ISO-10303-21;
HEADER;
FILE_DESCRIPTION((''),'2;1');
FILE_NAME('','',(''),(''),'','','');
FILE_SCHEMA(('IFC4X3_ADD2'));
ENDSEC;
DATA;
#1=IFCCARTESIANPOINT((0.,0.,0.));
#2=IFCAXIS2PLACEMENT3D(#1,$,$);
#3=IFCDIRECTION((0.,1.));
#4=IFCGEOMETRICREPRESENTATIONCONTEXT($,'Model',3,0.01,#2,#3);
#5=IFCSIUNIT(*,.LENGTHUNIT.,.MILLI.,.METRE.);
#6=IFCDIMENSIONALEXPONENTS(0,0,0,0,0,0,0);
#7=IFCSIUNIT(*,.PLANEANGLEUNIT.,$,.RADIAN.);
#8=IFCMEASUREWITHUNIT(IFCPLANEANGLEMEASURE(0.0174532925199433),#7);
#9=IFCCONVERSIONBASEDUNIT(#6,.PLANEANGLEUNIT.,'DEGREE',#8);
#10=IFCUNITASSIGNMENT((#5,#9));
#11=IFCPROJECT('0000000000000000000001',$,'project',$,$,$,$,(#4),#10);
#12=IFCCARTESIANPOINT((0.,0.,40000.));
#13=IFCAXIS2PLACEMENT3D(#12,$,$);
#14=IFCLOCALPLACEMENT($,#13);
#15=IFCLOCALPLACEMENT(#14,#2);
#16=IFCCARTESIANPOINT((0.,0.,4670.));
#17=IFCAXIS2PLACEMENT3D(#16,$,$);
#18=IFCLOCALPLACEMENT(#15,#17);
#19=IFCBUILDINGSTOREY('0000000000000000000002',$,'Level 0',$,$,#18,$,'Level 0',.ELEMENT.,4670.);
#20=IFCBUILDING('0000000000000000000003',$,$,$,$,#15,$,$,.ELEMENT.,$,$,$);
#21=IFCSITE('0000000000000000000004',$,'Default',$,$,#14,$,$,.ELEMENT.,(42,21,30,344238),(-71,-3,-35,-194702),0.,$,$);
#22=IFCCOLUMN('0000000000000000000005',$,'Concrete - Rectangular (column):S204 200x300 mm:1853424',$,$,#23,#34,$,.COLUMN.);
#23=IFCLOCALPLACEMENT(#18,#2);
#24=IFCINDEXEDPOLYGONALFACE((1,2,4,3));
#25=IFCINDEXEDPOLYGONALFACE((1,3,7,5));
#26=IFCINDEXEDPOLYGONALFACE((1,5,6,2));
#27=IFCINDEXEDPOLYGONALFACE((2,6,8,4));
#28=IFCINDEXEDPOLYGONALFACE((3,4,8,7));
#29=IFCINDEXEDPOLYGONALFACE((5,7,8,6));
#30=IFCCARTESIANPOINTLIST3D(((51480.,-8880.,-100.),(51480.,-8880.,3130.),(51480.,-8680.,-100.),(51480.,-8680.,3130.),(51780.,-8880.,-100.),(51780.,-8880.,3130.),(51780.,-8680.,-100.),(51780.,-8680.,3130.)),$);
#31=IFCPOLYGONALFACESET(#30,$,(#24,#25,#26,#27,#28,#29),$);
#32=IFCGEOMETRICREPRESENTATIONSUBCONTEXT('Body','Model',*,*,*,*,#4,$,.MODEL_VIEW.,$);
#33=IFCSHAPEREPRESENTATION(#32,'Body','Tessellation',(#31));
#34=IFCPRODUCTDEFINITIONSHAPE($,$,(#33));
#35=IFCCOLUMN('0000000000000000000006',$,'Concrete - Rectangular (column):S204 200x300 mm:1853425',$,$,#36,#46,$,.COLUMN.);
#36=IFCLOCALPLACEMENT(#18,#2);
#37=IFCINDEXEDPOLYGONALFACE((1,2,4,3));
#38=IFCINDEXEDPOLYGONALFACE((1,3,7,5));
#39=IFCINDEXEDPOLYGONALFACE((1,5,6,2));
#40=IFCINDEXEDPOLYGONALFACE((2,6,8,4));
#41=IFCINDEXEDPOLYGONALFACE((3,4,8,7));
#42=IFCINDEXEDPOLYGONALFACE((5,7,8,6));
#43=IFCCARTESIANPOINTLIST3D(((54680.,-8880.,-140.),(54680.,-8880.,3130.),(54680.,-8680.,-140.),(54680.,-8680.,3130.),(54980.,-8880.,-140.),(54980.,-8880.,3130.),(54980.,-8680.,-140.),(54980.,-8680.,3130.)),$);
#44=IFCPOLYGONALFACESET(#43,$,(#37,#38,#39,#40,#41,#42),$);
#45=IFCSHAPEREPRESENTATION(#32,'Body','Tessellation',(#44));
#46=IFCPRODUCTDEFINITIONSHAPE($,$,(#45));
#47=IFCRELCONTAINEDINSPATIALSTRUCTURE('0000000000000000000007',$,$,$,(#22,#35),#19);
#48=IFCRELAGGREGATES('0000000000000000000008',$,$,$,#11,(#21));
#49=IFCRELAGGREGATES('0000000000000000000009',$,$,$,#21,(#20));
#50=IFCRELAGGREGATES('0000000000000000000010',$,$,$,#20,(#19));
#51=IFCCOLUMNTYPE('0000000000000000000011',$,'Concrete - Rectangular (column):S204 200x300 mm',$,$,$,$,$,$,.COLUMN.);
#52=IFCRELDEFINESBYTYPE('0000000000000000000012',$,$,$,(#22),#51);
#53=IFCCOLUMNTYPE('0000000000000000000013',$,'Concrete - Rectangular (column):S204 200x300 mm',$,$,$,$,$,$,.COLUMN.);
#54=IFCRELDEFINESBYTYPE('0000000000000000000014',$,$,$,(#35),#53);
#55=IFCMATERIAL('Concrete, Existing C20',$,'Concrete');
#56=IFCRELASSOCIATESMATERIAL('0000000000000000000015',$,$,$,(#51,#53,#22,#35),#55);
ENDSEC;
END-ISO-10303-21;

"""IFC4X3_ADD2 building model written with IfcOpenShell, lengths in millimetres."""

from ifc_helpers import new_model, entity, si_unit, converted_unit, direction, frame, frame_2d, origin, place, context, subcontext, project, spatial, rectangle, extrude, source, transform, mapped, material, material_profile, profile_set, profile_usage, type_object, type_shapes, element, save


model = new_model("IFC4X3_ADD2")

# Units and contexts
model_context = context("Model", 3, precision=0.01, world=origin(), true_north=direction((0.0, 1.0)))
body_context = subcontext(model_context, "Body", "Model", "MODEL_VIEW")
ifc_project = project(units=[si_unit("LENGTHUNIT", "METRE", prefix="MILLI"), converted_unit("PLANEANGLEUNIT", "DEGREE", entity("IfcPlaneAngleMeasure", 0.0174532925199433), si_unit("PLANEANGLEUNIT", "RADIAN"), dimensions=[0, 0, 0, 0, 0, 0, 0])], contexts=[model_context])

# Site, building, storey
site_placement = place(None, frame((0.0, 0.0, 40000.0)))
site = spatial("IfcSite", under=ifc_project, at=site_placement, Name="Default", CompositionType="ELEMENT", RefLatitude=(42, 21, 30, 344238), RefLongitude=(-71, -3, -35, -194702), RefElevation=0.0)
building_placement = place(site_placement, origin())
building = spatial("IfcBuilding", under=site, at=building_placement, CompositionType="ELEMENT")
storey_placement = place(building_placement, frame((0.0, 0.0, 4670.0)))
storey = spatial("IfcBuildingStorey", under=building, at=storey_placement, Name="Level 0", LongName="Level 0", CompositionType="ELEMENT", Elevation=4670.0)

# Columns
ifc_material = material(Name="Concrete, Existing C20", Category="Concrete")
ifc_material_profile_1 = material_profile(ifc_material, rectangle(XDim=200.0, YDim=300.0, at=frame_2d((0.0, 0.0), x_axis=(1.0, 0.0))), Name="S204 200x300 mm")
ifc_profile_set_1 = profile_set([ifc_material_profile_1], Name="S204 200x300 mm")
ifc_profile_usage_1 = profile_usage(ifc_profile_set_1)
column_type_1 = type_object("IfcColumnType", Name="Concrete - Rectangular (column):S204 200x300 mm", PredefinedType="COLUMN", material=ifc_profile_set_1)
shared_shape_1 = source(origin(), body_context, "Body", "SweptSolid", [
    extrude(rectangle(XDim=200.0, YDim=300.0, at=frame_2d((0.0, 0.0), x_axis=(1.0, 0.0))), frame((51630.0, -8780.0, 4570.0), z_axis=(0.0, 0.0, 1.0), x_axis=(0.0, 1.0, 0.0)), (0.0, 0.0, 1.0), 3230.0),
])
type_shapes(column_type_1, [shared_shape_1])
column_1_placement = place(storey_placement, frame((0.0, 0.0, -4670.0)))
element("IfcColumn", 1, at=column_1_placement, inside=storey, type_object=column_type_1, material=ifc_profile_usage_1, Name="Concrete - Rectangular (column):S204 200x300 mm:1853424", PredefinedType="COLUMN", context=body_context, shape_type="MappedRepresentation", body=[
    mapped(shared_shape_1, transform((0.0, 0.0, 0.0), scale=1.0)),
])
column_type_2 = type_object("IfcColumnType", Name="Concrete - Rectangular (column):S204 200x300 mm", PredefinedType="COLUMN", material=ifc_profile_set_1)
shared_shape_2 = source(origin(), body_context, "Body", "SweptSolid", [
    extrude(rectangle(XDim=200.0, YDim=300.0, at=frame_2d((0.0, 0.0), x_axis=(1.0, 0.0))), frame((54830.0, -8780.0, 4530.0), z_axis=(0.0, 0.0, 1.0), x_axis=(0.0, 1.0, 0.0)), (0.0, 0.0, 1.0), 3270.0),
])
type_shapes(column_type_2, [shared_shape_2])
column_2_placement = place(storey_placement, frame((0.0, 0.0, -4670.0)))
element("IfcColumn", 2, at=column_2_placement, inside=storey, type_object=column_type_2, material=ifc_profile_usage_1, Name="Concrete - Rectangular (column):S204 200x300 mm:1853425", PredefinedType="COLUMN", context=body_context, shape_type="MappedRepresentation", body=[
    mapped(shared_shape_2, transform((0.0, 0.0, 0.0), scale=1.0)),
])

save(model, "model.ifc")
